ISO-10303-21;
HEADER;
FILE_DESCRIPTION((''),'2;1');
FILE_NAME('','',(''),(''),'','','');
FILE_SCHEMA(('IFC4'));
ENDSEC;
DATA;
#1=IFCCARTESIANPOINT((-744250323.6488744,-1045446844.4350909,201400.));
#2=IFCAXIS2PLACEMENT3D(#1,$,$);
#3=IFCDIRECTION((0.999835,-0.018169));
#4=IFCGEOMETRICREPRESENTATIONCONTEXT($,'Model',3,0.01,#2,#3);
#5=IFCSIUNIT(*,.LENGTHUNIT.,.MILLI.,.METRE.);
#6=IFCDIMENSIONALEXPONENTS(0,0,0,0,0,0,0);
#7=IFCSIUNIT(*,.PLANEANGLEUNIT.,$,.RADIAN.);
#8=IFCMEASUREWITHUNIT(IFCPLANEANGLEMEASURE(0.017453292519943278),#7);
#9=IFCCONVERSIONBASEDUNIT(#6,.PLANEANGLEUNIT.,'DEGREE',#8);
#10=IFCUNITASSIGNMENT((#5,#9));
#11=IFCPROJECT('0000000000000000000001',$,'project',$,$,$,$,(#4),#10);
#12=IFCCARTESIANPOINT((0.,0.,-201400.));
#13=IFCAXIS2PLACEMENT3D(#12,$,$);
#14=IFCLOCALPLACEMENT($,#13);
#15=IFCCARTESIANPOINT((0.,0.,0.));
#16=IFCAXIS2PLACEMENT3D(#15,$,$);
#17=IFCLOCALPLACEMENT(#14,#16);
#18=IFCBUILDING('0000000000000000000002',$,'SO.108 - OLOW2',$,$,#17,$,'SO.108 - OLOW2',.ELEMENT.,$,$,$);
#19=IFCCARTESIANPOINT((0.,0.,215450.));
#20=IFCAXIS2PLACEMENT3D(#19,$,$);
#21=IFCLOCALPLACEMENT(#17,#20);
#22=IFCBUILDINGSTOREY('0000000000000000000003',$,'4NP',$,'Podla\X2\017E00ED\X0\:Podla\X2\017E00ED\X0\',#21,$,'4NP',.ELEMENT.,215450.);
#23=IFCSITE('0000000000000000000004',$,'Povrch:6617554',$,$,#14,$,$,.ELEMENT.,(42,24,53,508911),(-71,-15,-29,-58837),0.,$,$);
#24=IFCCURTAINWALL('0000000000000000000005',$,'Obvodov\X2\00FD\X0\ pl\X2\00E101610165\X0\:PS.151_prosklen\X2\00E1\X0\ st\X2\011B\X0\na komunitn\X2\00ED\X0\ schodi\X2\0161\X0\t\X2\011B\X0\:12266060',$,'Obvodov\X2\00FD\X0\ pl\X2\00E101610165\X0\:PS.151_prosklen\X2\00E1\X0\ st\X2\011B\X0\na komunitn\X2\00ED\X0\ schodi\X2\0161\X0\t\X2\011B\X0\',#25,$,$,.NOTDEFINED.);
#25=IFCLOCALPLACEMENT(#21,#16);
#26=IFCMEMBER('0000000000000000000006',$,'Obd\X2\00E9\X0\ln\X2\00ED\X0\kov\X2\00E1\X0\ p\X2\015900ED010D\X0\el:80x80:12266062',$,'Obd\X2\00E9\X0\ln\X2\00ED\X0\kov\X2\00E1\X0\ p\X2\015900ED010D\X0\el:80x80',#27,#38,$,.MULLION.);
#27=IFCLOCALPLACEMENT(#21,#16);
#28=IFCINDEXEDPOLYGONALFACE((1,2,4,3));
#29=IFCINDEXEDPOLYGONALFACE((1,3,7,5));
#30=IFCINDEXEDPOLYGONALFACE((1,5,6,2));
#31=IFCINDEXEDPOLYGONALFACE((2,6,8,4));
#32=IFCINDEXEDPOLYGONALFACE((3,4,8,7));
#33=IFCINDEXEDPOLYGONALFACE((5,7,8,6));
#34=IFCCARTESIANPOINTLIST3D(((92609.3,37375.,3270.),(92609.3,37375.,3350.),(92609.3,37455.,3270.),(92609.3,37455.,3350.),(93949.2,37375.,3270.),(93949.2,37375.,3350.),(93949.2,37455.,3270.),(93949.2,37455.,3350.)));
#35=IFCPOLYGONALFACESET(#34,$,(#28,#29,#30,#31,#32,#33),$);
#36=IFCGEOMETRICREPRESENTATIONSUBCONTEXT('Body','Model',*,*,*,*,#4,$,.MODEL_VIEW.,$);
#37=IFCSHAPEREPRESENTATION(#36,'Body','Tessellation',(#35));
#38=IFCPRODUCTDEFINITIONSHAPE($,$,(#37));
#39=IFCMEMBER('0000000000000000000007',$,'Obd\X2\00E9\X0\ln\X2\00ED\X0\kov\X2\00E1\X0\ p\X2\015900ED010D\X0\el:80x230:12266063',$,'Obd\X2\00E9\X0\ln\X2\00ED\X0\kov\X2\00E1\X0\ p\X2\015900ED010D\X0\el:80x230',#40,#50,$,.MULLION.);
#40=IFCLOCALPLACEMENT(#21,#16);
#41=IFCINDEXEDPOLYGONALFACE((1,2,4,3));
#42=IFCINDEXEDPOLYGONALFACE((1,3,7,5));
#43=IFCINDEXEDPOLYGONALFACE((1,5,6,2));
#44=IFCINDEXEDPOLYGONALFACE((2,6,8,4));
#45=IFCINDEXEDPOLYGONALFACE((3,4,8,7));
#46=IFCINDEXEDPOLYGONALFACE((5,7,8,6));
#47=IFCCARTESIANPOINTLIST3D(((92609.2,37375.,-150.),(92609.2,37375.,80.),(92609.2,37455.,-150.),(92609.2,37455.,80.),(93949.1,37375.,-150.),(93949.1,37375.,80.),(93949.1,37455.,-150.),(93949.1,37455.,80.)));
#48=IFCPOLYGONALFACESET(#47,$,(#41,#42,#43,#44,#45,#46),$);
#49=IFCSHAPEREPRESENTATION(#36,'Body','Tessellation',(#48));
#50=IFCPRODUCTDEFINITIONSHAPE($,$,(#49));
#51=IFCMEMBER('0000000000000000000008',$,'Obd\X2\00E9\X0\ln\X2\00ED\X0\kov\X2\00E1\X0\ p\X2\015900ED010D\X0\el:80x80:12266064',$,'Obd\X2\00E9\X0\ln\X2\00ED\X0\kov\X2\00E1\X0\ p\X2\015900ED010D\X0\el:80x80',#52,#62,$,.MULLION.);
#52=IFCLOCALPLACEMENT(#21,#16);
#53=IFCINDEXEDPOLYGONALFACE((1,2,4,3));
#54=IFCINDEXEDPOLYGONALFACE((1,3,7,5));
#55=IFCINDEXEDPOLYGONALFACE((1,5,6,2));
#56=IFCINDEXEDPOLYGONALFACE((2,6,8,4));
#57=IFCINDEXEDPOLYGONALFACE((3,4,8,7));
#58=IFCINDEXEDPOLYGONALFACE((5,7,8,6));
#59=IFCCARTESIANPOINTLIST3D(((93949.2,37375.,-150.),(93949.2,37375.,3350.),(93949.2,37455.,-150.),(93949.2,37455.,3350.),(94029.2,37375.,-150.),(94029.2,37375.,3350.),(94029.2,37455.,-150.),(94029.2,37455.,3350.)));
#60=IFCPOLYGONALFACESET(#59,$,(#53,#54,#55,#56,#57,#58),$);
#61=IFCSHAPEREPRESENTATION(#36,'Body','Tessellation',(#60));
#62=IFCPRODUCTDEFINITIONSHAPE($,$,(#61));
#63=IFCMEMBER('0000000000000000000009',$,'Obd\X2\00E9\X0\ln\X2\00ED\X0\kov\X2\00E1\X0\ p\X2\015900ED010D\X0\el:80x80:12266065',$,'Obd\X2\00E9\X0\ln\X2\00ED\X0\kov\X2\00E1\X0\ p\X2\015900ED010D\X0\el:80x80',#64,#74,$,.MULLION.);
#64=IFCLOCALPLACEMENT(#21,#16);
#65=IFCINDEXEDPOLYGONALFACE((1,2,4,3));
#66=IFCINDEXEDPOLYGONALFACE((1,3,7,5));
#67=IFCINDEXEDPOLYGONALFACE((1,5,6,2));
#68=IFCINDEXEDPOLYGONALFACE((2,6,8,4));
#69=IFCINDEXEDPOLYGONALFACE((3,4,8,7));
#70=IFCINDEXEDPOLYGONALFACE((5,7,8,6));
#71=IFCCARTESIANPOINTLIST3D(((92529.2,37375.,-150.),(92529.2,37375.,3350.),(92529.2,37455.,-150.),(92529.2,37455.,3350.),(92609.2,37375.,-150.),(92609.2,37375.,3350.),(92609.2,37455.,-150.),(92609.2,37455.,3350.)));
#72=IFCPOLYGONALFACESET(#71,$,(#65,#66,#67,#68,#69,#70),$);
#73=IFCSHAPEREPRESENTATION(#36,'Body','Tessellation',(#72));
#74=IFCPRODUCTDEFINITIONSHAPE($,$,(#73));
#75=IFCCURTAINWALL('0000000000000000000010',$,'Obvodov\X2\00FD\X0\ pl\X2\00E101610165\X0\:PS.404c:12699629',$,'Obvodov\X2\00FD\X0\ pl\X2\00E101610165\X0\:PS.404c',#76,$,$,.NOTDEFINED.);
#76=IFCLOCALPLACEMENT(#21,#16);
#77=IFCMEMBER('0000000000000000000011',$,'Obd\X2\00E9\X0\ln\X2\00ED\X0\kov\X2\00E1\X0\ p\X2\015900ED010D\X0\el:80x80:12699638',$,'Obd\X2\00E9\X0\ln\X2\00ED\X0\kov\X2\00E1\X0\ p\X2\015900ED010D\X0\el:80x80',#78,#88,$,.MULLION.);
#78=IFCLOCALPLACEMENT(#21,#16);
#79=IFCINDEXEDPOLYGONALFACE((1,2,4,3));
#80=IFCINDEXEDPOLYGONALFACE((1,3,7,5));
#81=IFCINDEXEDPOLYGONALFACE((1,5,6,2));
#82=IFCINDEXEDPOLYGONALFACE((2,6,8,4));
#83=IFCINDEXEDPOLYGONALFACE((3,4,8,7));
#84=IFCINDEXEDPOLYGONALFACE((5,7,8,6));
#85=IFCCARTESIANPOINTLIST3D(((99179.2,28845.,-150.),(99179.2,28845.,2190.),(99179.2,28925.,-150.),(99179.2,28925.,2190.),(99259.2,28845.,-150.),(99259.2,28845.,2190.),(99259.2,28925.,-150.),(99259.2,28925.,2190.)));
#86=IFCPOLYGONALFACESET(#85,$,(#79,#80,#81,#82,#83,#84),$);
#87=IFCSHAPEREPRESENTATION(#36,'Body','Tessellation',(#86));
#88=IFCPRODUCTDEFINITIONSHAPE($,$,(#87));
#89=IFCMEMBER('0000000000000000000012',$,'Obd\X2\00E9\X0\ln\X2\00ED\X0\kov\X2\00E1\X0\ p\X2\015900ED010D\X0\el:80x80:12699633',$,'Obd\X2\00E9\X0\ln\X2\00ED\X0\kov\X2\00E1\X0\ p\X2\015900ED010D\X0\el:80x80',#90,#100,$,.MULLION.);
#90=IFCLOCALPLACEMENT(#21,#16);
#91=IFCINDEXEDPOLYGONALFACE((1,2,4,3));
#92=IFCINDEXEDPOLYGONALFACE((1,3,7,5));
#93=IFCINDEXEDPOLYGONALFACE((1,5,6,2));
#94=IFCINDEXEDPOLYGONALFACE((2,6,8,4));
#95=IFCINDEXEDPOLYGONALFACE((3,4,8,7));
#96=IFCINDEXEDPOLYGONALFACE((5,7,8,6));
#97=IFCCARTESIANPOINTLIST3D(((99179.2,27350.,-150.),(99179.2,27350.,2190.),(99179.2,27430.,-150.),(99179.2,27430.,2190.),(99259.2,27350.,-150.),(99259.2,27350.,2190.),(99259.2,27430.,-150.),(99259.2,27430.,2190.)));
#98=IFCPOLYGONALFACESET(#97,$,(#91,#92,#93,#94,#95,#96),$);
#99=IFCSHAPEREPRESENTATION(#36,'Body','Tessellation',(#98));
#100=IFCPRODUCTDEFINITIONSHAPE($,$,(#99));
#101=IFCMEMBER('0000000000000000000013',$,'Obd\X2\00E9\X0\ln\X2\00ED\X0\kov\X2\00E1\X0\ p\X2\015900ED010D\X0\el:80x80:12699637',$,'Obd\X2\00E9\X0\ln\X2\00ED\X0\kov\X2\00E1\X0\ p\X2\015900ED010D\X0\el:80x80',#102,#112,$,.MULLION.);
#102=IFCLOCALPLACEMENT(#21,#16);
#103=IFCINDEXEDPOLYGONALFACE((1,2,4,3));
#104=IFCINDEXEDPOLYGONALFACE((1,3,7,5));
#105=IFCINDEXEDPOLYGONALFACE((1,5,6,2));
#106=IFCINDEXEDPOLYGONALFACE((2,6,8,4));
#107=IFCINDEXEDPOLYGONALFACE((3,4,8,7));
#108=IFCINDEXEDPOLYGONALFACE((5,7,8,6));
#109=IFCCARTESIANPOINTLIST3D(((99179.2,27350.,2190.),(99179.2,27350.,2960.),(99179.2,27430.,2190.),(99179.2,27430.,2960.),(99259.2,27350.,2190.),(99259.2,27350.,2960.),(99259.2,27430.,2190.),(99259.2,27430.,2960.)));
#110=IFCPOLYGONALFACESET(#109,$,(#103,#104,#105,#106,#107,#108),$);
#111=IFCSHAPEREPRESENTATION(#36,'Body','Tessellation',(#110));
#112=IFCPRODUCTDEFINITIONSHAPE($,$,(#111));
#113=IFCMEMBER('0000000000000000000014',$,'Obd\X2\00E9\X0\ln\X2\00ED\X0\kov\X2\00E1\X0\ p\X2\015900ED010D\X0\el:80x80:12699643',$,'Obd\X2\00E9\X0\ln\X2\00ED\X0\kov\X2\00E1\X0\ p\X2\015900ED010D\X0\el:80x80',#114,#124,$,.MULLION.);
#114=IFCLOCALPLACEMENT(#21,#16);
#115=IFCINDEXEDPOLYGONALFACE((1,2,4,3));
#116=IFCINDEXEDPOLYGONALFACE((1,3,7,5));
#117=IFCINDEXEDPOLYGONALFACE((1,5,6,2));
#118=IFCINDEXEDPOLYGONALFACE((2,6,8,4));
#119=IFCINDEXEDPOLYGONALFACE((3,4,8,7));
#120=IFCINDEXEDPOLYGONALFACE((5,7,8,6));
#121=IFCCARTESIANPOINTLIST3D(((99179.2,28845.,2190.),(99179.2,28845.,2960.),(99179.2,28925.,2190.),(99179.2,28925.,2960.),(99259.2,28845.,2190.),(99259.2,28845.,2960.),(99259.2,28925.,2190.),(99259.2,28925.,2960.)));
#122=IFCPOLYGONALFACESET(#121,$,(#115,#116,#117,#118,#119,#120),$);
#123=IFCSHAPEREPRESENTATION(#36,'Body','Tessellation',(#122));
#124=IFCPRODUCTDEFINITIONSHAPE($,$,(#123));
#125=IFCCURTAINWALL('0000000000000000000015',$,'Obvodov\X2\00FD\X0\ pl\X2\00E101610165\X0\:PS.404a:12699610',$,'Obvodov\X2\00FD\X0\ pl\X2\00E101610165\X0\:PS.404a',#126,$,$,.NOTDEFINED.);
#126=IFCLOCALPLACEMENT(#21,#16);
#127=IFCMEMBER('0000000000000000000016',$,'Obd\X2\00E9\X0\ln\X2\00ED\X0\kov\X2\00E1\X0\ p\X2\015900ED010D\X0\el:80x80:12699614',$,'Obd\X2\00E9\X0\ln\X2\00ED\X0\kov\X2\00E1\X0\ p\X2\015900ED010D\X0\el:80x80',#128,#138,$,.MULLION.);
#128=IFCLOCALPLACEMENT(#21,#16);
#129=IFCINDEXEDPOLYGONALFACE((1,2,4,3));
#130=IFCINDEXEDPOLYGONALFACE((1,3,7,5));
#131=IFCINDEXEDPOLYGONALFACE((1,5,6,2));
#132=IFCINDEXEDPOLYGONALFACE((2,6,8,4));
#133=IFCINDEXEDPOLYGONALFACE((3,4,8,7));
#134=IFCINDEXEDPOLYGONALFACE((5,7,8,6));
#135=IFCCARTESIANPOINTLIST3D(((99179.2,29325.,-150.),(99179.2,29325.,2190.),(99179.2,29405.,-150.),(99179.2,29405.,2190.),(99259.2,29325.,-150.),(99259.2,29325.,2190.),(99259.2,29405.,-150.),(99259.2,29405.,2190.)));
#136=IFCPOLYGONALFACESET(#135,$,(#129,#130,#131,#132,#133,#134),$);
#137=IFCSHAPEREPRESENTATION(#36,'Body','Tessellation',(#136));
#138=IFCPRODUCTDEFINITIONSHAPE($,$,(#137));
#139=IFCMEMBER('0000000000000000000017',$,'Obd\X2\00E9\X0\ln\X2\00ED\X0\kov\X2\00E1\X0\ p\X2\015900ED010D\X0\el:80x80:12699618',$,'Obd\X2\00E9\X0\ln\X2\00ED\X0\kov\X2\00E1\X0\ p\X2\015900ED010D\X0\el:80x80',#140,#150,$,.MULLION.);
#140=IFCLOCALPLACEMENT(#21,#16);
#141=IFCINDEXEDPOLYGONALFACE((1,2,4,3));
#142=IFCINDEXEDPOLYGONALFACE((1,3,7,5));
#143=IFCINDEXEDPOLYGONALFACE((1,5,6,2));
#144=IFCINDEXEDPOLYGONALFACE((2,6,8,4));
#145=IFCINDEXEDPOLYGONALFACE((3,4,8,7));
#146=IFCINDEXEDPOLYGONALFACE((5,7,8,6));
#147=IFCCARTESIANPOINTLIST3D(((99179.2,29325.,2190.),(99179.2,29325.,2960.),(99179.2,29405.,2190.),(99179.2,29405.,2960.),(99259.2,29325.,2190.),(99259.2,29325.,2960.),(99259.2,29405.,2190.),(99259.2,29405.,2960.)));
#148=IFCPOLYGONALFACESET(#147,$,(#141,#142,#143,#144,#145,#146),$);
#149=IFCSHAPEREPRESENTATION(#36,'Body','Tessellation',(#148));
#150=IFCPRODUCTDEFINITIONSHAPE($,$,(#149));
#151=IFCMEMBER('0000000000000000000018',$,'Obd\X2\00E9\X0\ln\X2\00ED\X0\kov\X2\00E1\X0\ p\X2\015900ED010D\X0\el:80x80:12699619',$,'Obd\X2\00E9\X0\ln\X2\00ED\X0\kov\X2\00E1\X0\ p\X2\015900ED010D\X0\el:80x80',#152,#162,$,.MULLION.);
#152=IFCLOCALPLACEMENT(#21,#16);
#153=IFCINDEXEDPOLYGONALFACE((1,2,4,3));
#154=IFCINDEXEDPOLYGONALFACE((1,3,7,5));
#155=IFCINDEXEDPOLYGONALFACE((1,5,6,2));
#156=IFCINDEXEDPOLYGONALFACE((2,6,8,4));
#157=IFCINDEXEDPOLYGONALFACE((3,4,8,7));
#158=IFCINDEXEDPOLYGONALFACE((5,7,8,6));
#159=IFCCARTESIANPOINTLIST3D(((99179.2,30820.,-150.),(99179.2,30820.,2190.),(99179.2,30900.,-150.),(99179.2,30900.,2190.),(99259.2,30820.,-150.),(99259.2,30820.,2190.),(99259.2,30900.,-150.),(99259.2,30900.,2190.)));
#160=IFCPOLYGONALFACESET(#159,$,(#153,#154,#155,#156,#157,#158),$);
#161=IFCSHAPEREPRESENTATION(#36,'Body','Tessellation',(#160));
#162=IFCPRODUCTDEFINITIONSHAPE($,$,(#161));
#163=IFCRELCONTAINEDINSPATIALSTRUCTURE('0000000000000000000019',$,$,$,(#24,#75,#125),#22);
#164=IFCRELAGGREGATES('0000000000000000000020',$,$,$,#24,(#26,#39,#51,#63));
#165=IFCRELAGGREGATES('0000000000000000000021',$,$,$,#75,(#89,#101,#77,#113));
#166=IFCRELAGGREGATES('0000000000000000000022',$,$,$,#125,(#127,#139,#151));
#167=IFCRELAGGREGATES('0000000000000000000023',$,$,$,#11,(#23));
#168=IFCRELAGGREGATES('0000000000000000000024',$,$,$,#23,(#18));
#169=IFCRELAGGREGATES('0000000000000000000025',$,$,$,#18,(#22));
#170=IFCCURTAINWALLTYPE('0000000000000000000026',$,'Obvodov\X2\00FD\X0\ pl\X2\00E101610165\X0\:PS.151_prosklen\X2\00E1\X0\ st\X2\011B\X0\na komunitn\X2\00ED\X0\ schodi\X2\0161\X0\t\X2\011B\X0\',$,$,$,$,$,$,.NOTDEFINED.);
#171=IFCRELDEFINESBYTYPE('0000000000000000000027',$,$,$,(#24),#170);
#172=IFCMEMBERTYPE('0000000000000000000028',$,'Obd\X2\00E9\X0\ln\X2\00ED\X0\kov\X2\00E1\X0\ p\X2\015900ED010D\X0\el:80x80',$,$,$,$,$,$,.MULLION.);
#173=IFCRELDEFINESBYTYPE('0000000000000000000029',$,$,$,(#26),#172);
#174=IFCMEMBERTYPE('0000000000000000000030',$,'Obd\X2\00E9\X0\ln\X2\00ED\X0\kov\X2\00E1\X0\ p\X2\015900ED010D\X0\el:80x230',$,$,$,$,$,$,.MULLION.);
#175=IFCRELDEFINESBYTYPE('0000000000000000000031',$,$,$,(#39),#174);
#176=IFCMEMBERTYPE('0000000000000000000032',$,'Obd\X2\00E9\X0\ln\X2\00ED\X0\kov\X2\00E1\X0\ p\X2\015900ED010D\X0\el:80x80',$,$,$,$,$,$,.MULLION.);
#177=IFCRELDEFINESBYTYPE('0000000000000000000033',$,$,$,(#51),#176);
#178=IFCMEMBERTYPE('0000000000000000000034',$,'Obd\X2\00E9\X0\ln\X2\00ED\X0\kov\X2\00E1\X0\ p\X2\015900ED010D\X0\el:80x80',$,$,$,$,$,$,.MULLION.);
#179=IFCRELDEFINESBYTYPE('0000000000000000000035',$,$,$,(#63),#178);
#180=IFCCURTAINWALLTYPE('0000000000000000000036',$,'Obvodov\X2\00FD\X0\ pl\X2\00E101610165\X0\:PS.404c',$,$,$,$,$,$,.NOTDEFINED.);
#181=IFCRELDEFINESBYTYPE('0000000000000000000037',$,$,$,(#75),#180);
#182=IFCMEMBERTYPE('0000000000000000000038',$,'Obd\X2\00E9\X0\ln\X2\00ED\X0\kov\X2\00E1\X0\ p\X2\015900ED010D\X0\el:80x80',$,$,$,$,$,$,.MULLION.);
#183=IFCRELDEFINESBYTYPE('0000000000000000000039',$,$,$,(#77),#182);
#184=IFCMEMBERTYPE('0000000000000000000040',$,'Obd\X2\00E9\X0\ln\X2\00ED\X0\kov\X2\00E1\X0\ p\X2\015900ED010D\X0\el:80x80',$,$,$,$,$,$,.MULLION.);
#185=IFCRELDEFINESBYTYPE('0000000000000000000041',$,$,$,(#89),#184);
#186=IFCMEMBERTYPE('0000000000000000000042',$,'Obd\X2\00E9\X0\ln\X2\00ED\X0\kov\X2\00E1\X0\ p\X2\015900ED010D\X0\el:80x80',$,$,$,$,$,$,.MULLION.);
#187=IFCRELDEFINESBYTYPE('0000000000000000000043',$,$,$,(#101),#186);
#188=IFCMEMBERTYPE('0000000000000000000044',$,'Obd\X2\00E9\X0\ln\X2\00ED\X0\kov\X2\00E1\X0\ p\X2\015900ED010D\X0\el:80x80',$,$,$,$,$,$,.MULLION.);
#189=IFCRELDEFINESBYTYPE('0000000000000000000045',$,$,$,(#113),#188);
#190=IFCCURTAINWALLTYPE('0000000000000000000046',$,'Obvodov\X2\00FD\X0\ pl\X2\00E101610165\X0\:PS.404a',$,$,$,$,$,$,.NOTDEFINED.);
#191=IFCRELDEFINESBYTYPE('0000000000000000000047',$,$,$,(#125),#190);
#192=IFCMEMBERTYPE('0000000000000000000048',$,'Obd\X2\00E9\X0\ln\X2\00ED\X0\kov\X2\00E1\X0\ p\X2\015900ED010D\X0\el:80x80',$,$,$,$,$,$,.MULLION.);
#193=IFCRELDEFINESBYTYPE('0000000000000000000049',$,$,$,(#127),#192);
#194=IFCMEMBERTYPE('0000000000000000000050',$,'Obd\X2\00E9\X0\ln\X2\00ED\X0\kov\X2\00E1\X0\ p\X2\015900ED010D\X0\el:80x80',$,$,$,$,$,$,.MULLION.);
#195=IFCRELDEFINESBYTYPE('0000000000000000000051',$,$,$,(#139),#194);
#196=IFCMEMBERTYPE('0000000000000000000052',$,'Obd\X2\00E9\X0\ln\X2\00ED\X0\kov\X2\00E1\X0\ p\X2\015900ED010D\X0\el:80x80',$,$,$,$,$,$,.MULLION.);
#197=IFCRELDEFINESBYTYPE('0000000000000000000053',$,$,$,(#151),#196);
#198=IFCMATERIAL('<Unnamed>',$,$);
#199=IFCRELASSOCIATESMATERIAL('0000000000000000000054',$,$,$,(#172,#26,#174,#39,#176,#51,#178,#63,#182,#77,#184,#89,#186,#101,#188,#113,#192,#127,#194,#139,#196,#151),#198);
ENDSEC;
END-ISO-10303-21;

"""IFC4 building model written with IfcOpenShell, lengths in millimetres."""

from ifc_helpers import new_model, entity, si_unit, converted_unit, direction, frame, origin, place, context, subcontext, project, spatial, indexed_curve, outline, extrude, source, transform, mapped, material, type_object, type_shapes, element, aggregate, save


model = new_model("IFC4")

# Units and contexts
model_context = context("Model", 3, precision=0.01, world=frame((-744250323.6488744, -1045446844.4350909, 201400.0)), true_north=direction((0.999835, -0.018169)))
body_context = subcontext(model_context, "Body", "Model", "MODEL_VIEW")
ifc_project = project(units=[si_unit("LENGTHUNIT", "METRE", prefix="MILLI"), converted_unit("PLANEANGLEUNIT", "DEGREE", entity("IfcPlaneAngleMeasure", 0.017453292519943278), si_unit("PLANEANGLEUNIT", "RADIAN"), dimensions=[0, 0, 0, 0, 0, 0, 0])], contexts=[model_context])

# Site, building, storey
site_placement = place(None, frame((0.0, 0.0, -201400.0)))
site = spatial("IfcSite", under=ifc_project, at=site_placement, Name="Povrch:6617554", CompositionType="ELEMENT", RefLatitude=(42, 24, 53, 508911), RefLongitude=(-71, -15, -29, -58837), RefElevation=0.0)
building_placement = place(site_placement, origin())
building = spatial("IfcBuilding", under=site, at=building_placement, Name="SO.108 - OLOW2", LongName="SO.108 - OLOW2", CompositionType="ELEMENT")
storey_placement = place(building_placement, frame((0.0, 0.0, 215450.0)))
storey = spatial("IfcBuildingStorey", under=building, at=storey_placement, Name="4NP", ObjectType="Podlaží:Podlaží", LongName="4NP", CompositionType="ELEMENT", Elevation=215450.0)

# Curtain walls, members
curtain_wall_type_1 = type_object("IfcCurtainWallType", Name="Obvodový plášť:PS.151_prosklená stěna komunitní schodiště", PredefinedType="NOTDEFINED")
curtain_wall_1_placement = place(storey_placement, frame((0.0, 0.0, -215450.0)))
curtain_wall_1 = element("IfcCurtainWall", 1, at=curtain_wall_1_placement, inside=storey, type_object=curtain_wall_type_1, Name="Obvodový plášť:PS.151_prosklená stěna komunitní schodiště:12266060", ObjectType="Obvodový plášť:PS.151_prosklená stěna komunitní schodiště", PredefinedType="NOTDEFINED")
ifc_material_1 = material(Name="<Unnamed>")
member_type_1 = type_object("IfcMemberType", Name="Obdélníková příčel:80x80", PredefinedType="MULLION", material=ifc_material_1)
shared_shape_1 = source(origin(), body_context, "Body", "SweptSolid", [
    extrude(outline(indexed_curve([(-40.0, -40.0), (40.0, -40.0), (40.0, 40.0), (-40.0, 40.0), (-40.0, -40.0)], self_intersect=False)), frame((-40.0, 0.0, -1339.9), z_axis=(0.0, 0.0, 1.0), x_axis=(-1.0, 0.0, 0.0)), (0.0, 0.0, 1.0), 1339.9),
])
type_shapes(member_type_1, [shared_shape_1])
member_1_placement = place(curtain_wall_1_placement, frame((93949.2, 37415.0, 218800.0), z_axis=(1.0, 0.0, 0.0), x_axis=(0.0, 0.0, 1.0)))
member_1 = element("IfcMember", 2, at=member_1_placement, type_object=member_type_1, material=ifc_material_1, Name="Obdélníková příčel:80x80:12266062", ObjectType="Obdélníková příčel:80x80", PredefinedType="MULLION", context=body_context, shape_type="MappedRepresentation", body=[
    mapped(shared_shape_1, transform((0.0, 0.0, 0.0), scale=1.0)),
])
member_type_2 = type_object("IfcMemberType", Name="Obdélníková příčel:80x230", PredefinedType="MULLION", material=ifc_material_1)
shared_shape_2 = source(origin(), body_context, "Body", "SweptSolid", [
    extrude(outline(indexed_curve([(-115.0, -40.0), (115.0, -40.0), (115.0, 40.0), (-115.0, 40.0), (-115.0, -40.0)], self_intersect=False)), frame((-115.0, 0.0, -1339.9), z_axis=(0.0, 0.0, 1.0), x_axis=(-1.0, 0.0, 0.0)), (0.0, 0.0, 1.0), 1339.9),
])
type_shapes(member_type_2, [shared_shape_2])
member_2_placement = place(curtain_wall_1_placement, frame((92609.2, 37415.0, 215300.0), z_axis=(-1.0, 0.0, 0.0), x_axis=(0.0, 0.0, -1.0)))
member_2 = element("IfcMember", 3, at=member_2_placement, type_object=member_type_2, material=ifc_material_1, Name="Obdélníková příčel:80x230:12266063", ObjectType="Obdélníková příčel:80x230", PredefinedType="MULLION", context=body_context, shape_type="MappedRepresentation", body=[
    mapped(shared_shape_2, transform((0.0, 0.0, 0.0), scale=1.0)),
])
member_type_3 = type_object("IfcMemberType", Name="Obdélníková příčel:80x80", PredefinedType="MULLION", material=ifc_material_1)
shared_shape_3 = source(origin(), body_context, "Body", "SweptSolid", [
    extrude(outline(indexed_curve([(-40.0, -40.0), (40.0, -40.0), (40.0, 40.0), (-40.0, 40.0), (-40.0, -40.0)], self_intersect=False)), frame((-40.0, 0.0, -3500.0), z_axis=(0.0, 0.0, 1.0), x_axis=(-1.0, 0.0, 0.0)), (0.0, 0.0, 1.0), 3500.0),
])
type_shapes(member_type_3, [shared_shape_3])
member_3_placement = place(curtain_wall_1_placement, frame((94029.2, 37415.0, 215300.0), z_axis=(0.0, 0.0, -1.0), x_axis=(1.0, 0.0, 0.0)))
member_3 = element("IfcMember", 4, at=member_3_placement, type_object=member_type_3, material=ifc_material_1, Name="Obdélníková příčel:80x80:12266064", ObjectType="Obdélníková příčel:80x80", PredefinedType="MULLION", context=body_context, shape_type="MappedRepresentation", body=[
    mapped(shared_shape_3, transform((0.0, 0.0, 0.0), scale=1.0)),
])
member_type_4 = type_object("IfcMemberType", Name="Obdélníková příčel:80x80", PredefinedType="MULLION", material=ifc_material_1)
shared_shape_4 = source(origin(), body_context, "Body", "SweptSolid", [
    extrude(outline(indexed_curve([(-40.0, -40.0), (40.0, -40.0), (40.0, 40.0), (-40.0, 40.0), (-40.0, -40.0)], self_intersect=False)), frame((-40.0, 0.0, -3500.0), z_axis=(0.0, 0.0, 1.0), x_axis=(-1.0, 0.0, 0.0)), (0.0, 0.0, 1.0), 3500.0),
])
type_shapes(member_type_4, [shared_shape_4])
member_4_placement = place(curtain_wall_1_placement, frame((92529.2, 37415.0, 218800.0), z_axis=(0.0, 0.0, 1.0), x_axis=(-1.0, 0.0, 0.0)))
member_4 = element("IfcMember", 5, at=member_4_placement, type_object=member_type_4, material=ifc_material_1, Name="Obdélníková příčel:80x80:12266065", ObjectType="Obdélníková příčel:80x80", PredefinedType="MULLION", context=body_context, shape_type="MappedRepresentation", body=[
    mapped(shared_shape_4, transform((0.0, 0.0, 0.0), scale=1.0)),
])
curtain_wall_type_2 = type_object("IfcCurtainWallType", Name="Obvodový plášť:PS.404c", PredefinedType="NOTDEFINED")
curtain_wall_2_placement = place(storey_placement, frame((0.0, 0.0, -215450.0)))
curtain_wall_2 = element("IfcCurtainWall", 6, at=curtain_wall_2_placement, inside=storey, type_object=curtain_wall_type_2, Name="Obvodový plášť:PS.404c:12699629", ObjectType="Obvodový plášť:PS.404c", PredefinedType="NOTDEFINED")
member_type_5 = type_object("IfcMemberType", Name="Obdélníková příčel:80x80", PredefinedType="MULLION", material=ifc_material_1)
shared_shape_5 = source(origin(), body_context, "Body", "SweptSolid", [
    extrude(outline(indexed_curve([(-40.0, -40.0), (40.0, -40.0), (40.0, 40.0), (-40.0, 40.0), (-40.0, -40.0)], self_intersect=False)), frame((-40.0, 0.0, -2340.0), z_axis=(0.0, 0.0, 1.0), x_axis=(-1.0, 0.0, 0.0)), (0.0, 0.0, 1.0), 2340.0),
])
type_shapes(member_type_5, [shared_shape_5])
member_5_placement = place(curtain_wall_2_placement, frame((99219.2, 28925.0, 217640.0), z_axis=(0.0, 0.0, 1.0), x_axis=(0.0, 1.0, 0.0)))
member_5 = element("IfcMember", 7, at=member_5_placement, type_object=member_type_5, material=ifc_material_1, Name="Obdélníková příčel:80x80:12699638", ObjectType="Obdélníková příčel:80x80", PredefinedType="MULLION", context=body_context, shape_type="MappedRepresentation", body=[
    mapped(shared_shape_5, transform((0.0, 0.0, 0.0), scale=1.0)),
])
member_type_6 = type_object("IfcMemberType", Name="Obdélníková příčel:80x80", PredefinedType="MULLION", material=ifc_material_1)
shared_shape_6 = source(origin(), body_context, "Body", "SweptSolid", [
    extrude(outline(indexed_curve([(-40.0, -40.0), (40.0, -40.0), (40.0, 40.0), (-40.0, 40.0), (-40.0, -40.0)], self_intersect=False)), frame((-40.0, 0.0, -2340.0), z_axis=(0.0, 0.0, 1.0), x_axis=(-1.0, 0.0, 0.0)), (0.0, 0.0, 1.0), 2340.0),
])
type_shapes(member_type_6, [shared_shape_6])
member_6_placement = place(curtain_wall_2_placement, frame((99219.2, 27350.0, 215300.0), z_axis=(0.0, 0.0, -1.0), x_axis=(0.0, -1.0, 0.0)))
member_6 = element("IfcMember", 8, at=member_6_placement, type_object=member_type_6, material=ifc_material_1, Name="Obdélníková příčel:80x80:12699633", ObjectType="Obdélníková příčel:80x80", PredefinedType="MULLION", context=body_context, shape_type="MappedRepresentation", body=[
    mapped(shared_shape_6, transform((0.0, 0.0, 0.0), scale=1.0)),
])
member_type_7 = type_object("IfcMemberType", Name="Obdélníková příčel:80x80", PredefinedType="MULLION", material=ifc_material_1)
shared_shape_7 = source(origin(), body_context, "Body", "SweptSolid", [
    extrude(outline(indexed_curve([(-40.0, -40.0), (40.0, -40.0), (40.0, 40.0), (-40.0, 40.0), (-40.0, -40.0)], self_intersect=False)), frame((-40.0, 0.0, -770.0), z_axis=(0.0, 0.0, 1.0), x_axis=(-1.0, 0.0, 0.0)), (0.0, 0.0, 1.0), 770.0),
])
type_shapes(member_type_7, [shared_shape_7])
member_7_placement = place(curtain_wall_2_placement, frame((99219.2, 27350.0, 217640.0), z_axis=(0.0, 0.0, -1.0), x_axis=(0.0, -1.0, 0.0)))
member_7 = element("IfcMember", 9, at=member_7_placement, type_object=member_type_7, material=ifc_material_1, Name="Obdélníková příčel:80x80:12699637", ObjectType="Obdélníková příčel:80x80", PredefinedType="MULLION", context=body_context, shape_type="MappedRepresentation", body=[
    mapped(shared_shape_7, transform((0.0, 0.0, 0.0), scale=1.0)),
])
member_type_8 = type_object("IfcMemberType", Name="Obdélníková příčel:80x80", PredefinedType="MULLION", material=ifc_material_1)
shared_shape_8 = source(origin(), body_context, "Body", "SweptSolid", [
    extrude(outline(indexed_curve([(-40.0, -40.0), (40.0, -40.0), (40.0, 40.0), (-40.0, 40.0), (-40.0, -40.0)], self_intersect=False)), frame((-40.0, 0.0, -770.0), z_axis=(0.0, 0.0, 1.0), x_axis=(-1.0, 0.0, 0.0)), (0.0, 0.0, 1.0), 770.0),
])
type_shapes(member_type_8, [shared_shape_8])
member_8_placement = place(curtain_wall_2_placement, frame((99219.2, 28925.0, 218410.0), z_axis=(0.0, 0.0, 1.0), x_axis=(0.0, 1.0, 0.0)))
member_8 = element("IfcMember", 10, at=member_8_placement, type_object=member_type_8, material=ifc_material_1, Name="Obdélníková příčel:80x80:12699643", ObjectType="Obdélníková příčel:80x80", PredefinedType="MULLION", context=body_context, shape_type="MappedRepresentation", body=[
    mapped(shared_shape_8, transform((0.0, 0.0, 0.0), scale=1.0)),
])
curtain_wall_type_3 = type_object("IfcCurtainWallType", Name="Obvodový plášť:PS.404a", PredefinedType="NOTDEFINED")
curtain_wall_3_placement = place(storey_placement, frame((0.0, 0.0, -215450.0)))
curtain_wall_3 = element("IfcCurtainWall", 11, at=curtain_wall_3_placement, inside=storey, type_object=curtain_wall_type_3, Name="Obvodový plášť:PS.404a:12699610", ObjectType="Obvodový plášť:PS.404a", PredefinedType="NOTDEFINED")
member_type_9 = type_object("IfcMemberType", Name="Obdélníková příčel:80x80", PredefinedType="MULLION", material=ifc_material_1)
shared_shape_9 = source(origin(), body_context, "Body", "SweptSolid", [
    extrude(outline(indexed_curve([(-40.0, -40.0), (40.0, -40.0), (40.0, 40.0), (-40.0, 40.0), (-40.0, -40.0)], self_intersect=False)), frame((-40.0, 0.0, -2340.0), z_axis=(0.0, 0.0, 1.0), x_axis=(-1.0, 0.0, 0.0)), (0.0, 0.0, 1.0), 2340.0),
])
type_shapes(member_type_9, [shared_shape_9])
member_9_placement = place(curtain_wall_3_placement, frame((99219.2, 29325.0, 215300.0), z_axis=(0.0, 0.0, -1.0), x_axis=(0.0, -1.0, 0.0)))
member_9 = element("IfcMember", 12, at=member_9_placement, type_object=member_type_9, material=ifc_material_1, Name="Obdélníková příčel:80x80:12699614", ObjectType="Obdélníková příčel:80x80", PredefinedType="MULLION", context=body_context, shape_type="MappedRepresentation", body=[
    mapped(shared_shape_9, transform((0.0, 0.0, 0.0), scale=1.0)),
])
member_type_10 = type_object("IfcMemberType", Name="Obdélníková příčel:80x80", PredefinedType="MULLION", material=ifc_material_1)
shared_shape_10 = source(origin(), body_context, "Body", "SweptSolid", [
    extrude(outline(indexed_curve([(-40.0, -40.0), (40.0, -40.0), (40.0, 40.0), (-40.0, 40.0), (-40.0, -40.0)], self_intersect=False)), frame((-40.0, 0.0, -770.0), z_axis=(0.0, 0.0, 1.0), x_axis=(-1.0, 0.0, 0.0)), (0.0, 0.0, 1.0), 770.0),
])
type_shapes(member_type_10, [shared_shape_10])
member_10_placement = place(curtain_wall_3_placement, frame((99219.2, 29325.0, 217640.0), z_axis=(0.0, 0.0, -1.0), x_axis=(0.0, -1.0, 0.0)))
member_10 = element("IfcMember", 13, at=member_10_placement, type_object=member_type_10, material=ifc_material_1, Name="Obdélníková příčel:80x80:12699618", ObjectType="Obdélníková příčel:80x80", PredefinedType="MULLION", context=body_context, shape_type="MappedRepresentation", body=[
    mapped(shared_shape_10, transform((0.0, 0.0, 0.0), scale=1.0)),
])
member_type_11 = type_object("IfcMemberType", Name="Obdélníková příčel:80x80", PredefinedType="MULLION", material=ifc_material_1)
shared_shape_11 = source(origin(), body_context, "Body", "SweptSolid", [
    extrude(outline(indexed_curve([(-40.0, -40.0), (40.0, -40.0), (40.0, 40.0), (-40.0, 40.0), (-40.0, -40.0)], self_intersect=False)), frame((-40.0, 0.0, -2340.0), z_axis=(0.0, 0.0, 1.0), x_axis=(-1.0, 0.0, 0.0)), (0.0, 0.0, 1.0), 2340.0),
])
type_shapes(member_type_11, [shared_shape_11])
member_11_placement = place(curtain_wall_3_placement, frame((99219.2, 30900.0, 217640.0), z_axis=(0.0, 0.0, 1.0), x_axis=(0.0, 1.0, 0.0)))
member_11 = element("IfcMember", 14, at=member_11_placement, type_object=member_type_11, material=ifc_material_1, Name="Obdélníková příčel:80x80:12699619", ObjectType="Obdélníková příčel:80x80", PredefinedType="MULLION", context=body_context, shape_type="MappedRepresentation", body=[
    mapped(shared_shape_11, transform((0.0, 0.0, 0.0), scale=1.0)),
])

aggregate(curtain_wall_1, [member_1, member_2, member_3, member_4])
aggregate(curtain_wall_2, [member_6, member_7, member_5, member_8])

aggregate(curtain_wall_3, [member_9, member_10, member_11])

save(model, "model.ifc")
